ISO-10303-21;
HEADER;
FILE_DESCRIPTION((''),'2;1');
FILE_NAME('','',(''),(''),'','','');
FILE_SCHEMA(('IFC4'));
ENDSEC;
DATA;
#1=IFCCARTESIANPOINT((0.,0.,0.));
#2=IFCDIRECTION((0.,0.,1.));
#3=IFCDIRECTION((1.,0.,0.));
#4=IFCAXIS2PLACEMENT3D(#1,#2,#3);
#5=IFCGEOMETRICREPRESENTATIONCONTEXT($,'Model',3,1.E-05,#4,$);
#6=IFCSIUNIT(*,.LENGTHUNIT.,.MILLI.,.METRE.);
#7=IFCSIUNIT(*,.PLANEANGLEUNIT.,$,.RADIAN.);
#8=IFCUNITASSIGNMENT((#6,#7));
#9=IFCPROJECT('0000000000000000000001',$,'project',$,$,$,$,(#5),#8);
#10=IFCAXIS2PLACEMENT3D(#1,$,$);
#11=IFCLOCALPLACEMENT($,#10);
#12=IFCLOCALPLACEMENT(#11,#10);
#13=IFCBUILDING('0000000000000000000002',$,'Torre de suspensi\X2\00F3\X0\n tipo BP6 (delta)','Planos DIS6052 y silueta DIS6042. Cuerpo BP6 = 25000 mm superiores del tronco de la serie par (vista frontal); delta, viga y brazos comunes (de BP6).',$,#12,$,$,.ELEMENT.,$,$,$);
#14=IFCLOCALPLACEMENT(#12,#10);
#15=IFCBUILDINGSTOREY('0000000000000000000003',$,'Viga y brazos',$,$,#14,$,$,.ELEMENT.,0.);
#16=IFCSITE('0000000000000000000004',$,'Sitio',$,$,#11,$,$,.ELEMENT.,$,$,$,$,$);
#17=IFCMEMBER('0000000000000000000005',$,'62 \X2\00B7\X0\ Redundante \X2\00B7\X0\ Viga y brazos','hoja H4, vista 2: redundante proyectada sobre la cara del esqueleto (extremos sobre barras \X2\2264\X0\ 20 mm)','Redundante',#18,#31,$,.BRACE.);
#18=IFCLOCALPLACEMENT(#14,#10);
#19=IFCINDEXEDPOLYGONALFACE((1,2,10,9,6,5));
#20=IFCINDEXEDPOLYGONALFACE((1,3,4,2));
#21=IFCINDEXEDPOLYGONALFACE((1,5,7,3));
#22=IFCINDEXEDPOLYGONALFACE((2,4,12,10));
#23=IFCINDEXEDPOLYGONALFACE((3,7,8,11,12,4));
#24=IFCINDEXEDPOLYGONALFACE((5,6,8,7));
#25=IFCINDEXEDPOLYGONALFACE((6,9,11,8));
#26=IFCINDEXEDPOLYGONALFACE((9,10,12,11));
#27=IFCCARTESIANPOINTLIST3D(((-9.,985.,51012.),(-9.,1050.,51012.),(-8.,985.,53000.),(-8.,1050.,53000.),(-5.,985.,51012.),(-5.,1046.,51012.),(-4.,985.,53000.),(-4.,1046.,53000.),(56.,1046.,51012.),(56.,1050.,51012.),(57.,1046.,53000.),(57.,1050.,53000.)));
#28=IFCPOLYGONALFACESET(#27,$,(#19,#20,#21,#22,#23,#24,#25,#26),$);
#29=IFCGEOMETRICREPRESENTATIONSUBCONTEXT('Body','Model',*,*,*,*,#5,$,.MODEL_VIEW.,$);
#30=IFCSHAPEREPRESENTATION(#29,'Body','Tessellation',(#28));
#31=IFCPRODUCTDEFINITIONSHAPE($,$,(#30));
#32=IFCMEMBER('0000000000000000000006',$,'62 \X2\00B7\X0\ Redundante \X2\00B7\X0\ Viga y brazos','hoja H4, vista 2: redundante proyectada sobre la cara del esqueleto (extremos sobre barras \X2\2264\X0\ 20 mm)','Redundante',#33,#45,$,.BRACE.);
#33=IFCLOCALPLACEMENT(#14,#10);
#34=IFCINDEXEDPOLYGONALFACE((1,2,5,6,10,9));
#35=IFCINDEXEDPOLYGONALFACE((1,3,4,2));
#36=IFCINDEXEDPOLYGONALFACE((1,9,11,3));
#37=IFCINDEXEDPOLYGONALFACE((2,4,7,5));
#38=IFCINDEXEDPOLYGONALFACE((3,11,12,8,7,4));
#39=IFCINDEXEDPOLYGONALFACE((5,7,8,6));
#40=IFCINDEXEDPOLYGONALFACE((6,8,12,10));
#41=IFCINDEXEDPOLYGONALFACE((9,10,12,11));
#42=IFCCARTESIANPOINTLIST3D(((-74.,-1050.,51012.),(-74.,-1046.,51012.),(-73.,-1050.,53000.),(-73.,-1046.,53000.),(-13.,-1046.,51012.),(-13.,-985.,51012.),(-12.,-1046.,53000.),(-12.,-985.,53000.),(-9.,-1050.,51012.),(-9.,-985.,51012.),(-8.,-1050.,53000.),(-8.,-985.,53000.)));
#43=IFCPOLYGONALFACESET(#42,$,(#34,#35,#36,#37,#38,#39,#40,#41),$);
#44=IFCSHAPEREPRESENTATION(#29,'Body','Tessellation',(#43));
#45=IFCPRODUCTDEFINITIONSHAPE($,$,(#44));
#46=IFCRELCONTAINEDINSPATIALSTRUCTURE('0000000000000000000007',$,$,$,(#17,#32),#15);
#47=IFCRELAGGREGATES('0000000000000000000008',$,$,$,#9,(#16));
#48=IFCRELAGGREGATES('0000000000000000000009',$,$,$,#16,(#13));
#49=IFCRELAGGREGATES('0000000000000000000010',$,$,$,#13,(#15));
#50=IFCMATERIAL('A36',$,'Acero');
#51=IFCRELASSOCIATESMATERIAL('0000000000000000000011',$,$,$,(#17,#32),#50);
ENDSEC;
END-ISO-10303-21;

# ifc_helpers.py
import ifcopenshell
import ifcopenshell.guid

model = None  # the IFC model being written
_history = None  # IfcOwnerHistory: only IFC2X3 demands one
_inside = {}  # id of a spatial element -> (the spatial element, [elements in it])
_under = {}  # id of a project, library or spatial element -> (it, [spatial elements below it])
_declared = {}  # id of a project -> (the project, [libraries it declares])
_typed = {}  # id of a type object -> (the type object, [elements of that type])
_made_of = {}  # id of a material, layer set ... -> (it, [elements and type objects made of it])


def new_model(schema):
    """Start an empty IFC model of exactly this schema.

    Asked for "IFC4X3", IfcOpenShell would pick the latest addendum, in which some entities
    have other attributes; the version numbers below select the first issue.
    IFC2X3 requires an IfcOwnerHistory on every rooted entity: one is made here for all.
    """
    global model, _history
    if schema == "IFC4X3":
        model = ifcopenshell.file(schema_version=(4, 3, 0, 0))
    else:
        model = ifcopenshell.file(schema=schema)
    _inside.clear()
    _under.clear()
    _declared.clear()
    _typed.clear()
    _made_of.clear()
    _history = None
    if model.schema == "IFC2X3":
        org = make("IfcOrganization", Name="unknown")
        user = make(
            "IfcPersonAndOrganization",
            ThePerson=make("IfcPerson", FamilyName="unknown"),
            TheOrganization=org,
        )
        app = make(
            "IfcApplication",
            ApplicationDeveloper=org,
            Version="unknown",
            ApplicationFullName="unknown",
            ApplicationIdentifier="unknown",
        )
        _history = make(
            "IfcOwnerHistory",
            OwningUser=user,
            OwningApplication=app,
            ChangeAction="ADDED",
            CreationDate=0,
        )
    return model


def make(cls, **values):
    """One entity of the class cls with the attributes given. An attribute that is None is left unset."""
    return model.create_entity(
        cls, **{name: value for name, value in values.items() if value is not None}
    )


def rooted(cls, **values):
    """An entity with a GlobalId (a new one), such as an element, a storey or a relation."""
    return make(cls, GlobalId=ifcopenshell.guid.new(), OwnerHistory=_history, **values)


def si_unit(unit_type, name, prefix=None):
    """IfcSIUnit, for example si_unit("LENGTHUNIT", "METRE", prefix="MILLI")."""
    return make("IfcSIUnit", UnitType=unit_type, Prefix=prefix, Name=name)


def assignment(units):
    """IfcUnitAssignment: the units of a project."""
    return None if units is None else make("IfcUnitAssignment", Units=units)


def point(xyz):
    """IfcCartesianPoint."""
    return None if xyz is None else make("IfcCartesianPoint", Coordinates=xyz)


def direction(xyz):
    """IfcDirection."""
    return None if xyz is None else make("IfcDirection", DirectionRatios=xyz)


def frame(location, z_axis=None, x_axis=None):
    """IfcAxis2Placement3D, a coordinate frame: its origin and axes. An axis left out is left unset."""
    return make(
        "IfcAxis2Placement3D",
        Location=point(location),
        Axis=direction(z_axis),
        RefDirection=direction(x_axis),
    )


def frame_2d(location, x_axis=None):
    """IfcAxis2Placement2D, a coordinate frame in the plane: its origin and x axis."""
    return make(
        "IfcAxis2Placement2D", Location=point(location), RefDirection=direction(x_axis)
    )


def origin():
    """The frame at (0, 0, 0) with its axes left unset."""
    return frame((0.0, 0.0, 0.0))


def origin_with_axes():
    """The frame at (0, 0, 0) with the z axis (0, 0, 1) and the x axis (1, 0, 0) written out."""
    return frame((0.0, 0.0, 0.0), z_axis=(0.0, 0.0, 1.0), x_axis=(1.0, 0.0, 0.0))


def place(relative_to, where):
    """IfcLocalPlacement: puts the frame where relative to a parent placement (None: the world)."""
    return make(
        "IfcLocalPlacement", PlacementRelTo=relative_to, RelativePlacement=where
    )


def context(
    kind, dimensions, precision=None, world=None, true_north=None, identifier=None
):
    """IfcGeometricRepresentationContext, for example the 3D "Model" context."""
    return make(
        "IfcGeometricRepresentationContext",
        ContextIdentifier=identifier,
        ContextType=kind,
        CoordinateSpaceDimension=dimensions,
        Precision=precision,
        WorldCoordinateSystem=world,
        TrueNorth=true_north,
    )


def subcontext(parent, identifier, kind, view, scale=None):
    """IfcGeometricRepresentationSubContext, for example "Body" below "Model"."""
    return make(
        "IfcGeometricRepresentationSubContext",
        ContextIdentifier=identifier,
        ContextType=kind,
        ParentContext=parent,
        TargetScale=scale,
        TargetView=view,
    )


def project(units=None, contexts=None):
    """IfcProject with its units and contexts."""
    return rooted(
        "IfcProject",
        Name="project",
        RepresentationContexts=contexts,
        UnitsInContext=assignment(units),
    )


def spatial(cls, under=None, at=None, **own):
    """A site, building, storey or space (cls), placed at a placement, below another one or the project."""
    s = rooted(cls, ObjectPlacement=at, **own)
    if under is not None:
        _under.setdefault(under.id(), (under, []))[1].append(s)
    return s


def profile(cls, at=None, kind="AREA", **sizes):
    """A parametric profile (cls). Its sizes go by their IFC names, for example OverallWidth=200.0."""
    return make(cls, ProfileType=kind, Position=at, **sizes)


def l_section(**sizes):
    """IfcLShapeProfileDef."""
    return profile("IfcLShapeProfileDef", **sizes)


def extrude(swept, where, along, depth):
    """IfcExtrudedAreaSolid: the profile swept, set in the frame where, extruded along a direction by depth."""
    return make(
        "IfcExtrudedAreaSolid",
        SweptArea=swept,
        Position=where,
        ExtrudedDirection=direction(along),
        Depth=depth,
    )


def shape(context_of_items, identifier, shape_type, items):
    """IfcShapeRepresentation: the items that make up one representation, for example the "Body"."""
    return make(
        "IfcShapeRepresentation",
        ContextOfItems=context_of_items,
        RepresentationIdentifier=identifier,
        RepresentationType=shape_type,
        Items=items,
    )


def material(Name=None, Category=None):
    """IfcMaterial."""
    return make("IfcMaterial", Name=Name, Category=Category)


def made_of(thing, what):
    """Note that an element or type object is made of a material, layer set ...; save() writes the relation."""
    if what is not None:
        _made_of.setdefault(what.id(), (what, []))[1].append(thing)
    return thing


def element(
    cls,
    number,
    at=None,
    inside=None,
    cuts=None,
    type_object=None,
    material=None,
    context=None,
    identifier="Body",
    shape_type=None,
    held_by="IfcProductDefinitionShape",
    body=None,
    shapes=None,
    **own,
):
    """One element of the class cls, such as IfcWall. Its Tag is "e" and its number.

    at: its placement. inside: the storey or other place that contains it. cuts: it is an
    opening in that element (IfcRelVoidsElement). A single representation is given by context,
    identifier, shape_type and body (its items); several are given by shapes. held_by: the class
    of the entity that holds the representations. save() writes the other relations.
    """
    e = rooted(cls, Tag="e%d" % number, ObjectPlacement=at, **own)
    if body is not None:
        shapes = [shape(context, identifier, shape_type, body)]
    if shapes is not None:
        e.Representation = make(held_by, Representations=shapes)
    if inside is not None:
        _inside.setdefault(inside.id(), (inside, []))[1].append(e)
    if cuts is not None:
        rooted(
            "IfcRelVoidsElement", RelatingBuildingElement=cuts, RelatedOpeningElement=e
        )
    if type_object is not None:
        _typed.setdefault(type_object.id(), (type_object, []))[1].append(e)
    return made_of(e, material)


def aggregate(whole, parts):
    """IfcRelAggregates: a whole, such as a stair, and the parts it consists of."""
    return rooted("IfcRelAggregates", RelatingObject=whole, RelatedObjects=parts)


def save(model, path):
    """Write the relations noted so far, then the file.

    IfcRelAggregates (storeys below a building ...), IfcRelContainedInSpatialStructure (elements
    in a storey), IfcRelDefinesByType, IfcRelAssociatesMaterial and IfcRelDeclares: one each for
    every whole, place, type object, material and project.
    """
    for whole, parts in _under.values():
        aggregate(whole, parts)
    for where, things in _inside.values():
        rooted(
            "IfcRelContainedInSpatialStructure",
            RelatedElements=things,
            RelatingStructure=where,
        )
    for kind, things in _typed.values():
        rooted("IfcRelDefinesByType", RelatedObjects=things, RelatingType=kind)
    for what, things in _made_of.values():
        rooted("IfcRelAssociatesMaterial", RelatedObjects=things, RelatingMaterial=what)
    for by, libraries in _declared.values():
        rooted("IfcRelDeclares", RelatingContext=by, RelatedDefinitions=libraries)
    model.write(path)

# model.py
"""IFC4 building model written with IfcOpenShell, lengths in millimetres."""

from ifc_helpers import new_model, si_unit, frame, frame_2d, origin, origin_with_axes, place, context, subcontext, project, spatial, l_section, extrude, material, element, save


model = new_model("IFC4")

# Units and contexts
model_context = context("Model", 3, precision=1e-05, world=origin_with_axes())
body_context = subcontext(model_context, "Body", "Model", "MODEL_VIEW")
ifc_project = project(units=[si_unit("LENGTHUNIT", "METRE", prefix="MILLI"), si_unit("PLANEANGLEUNIT", "RADIAN")], contexts=[model_context])

# Site, building, storey
site_placement = place(None, origin())
site = spatial("IfcSite", under=ifc_project, at=site_placement, Name="Sitio", CompositionType="ELEMENT")
building_placement = place(site_placement, origin())
building = spatial("IfcBuilding", under=site, at=building_placement, Name="Torre de suspensión tipo BP6 (delta)", Description="Planos DIS6052 y silueta DIS6042. Cuerpo BP6 = 25000 mm superiores del tronco de la serie par (vista frontal); delta, viga y brazos comunes (de BP6).", CompositionType="ELEMENT")
storey_placement = place(building_placement, origin())
storey = spatial("IfcBuildingStorey", under=building, at=storey_placement, Name="Viga y brazos", CompositionType="ELEMENT", Elevation=0.0)

# Members
ifc_material_1 = material(Name="A36", Category="Acero")
for number, where, z_axis, x_axis, name in (
    (1, (-9.0, 1050.0, 51012.0), (0.000503, 0.0, 1.0), (0.0, -1.0, 0.0), "62 · Redundante · Viga y brazos"),
    (2, (-9.0, -1050.0, 51012.0), (0.000503, 0.0, 1.0), (0.0, 1.0, 0.0), "62 · Redundante · Viga y brazos"),
):
    element("IfcMember", number, at=place(storey_placement, frame(where, z_axis=z_axis, x_axis=x_axis)), inside=storey, material=ifc_material_1, Name=name, Description="hoja H4, vista 2: redundante proyectada sobre la cara del esqueleto (extremos sobre barras ≤ 20 mm)", ObjectType="Redundante", PredefinedType="BRACE", context=body_context, shape_type="SweptSolid", body=[
        extrude(l_section(Depth=65.0, Width=65.0, Thickness=4.0, at=frame_2d((32.5, 32.5))), None, (0.0, 0.0, 1.0), 1988.0),
    ])

save(model, "model.ifc")
